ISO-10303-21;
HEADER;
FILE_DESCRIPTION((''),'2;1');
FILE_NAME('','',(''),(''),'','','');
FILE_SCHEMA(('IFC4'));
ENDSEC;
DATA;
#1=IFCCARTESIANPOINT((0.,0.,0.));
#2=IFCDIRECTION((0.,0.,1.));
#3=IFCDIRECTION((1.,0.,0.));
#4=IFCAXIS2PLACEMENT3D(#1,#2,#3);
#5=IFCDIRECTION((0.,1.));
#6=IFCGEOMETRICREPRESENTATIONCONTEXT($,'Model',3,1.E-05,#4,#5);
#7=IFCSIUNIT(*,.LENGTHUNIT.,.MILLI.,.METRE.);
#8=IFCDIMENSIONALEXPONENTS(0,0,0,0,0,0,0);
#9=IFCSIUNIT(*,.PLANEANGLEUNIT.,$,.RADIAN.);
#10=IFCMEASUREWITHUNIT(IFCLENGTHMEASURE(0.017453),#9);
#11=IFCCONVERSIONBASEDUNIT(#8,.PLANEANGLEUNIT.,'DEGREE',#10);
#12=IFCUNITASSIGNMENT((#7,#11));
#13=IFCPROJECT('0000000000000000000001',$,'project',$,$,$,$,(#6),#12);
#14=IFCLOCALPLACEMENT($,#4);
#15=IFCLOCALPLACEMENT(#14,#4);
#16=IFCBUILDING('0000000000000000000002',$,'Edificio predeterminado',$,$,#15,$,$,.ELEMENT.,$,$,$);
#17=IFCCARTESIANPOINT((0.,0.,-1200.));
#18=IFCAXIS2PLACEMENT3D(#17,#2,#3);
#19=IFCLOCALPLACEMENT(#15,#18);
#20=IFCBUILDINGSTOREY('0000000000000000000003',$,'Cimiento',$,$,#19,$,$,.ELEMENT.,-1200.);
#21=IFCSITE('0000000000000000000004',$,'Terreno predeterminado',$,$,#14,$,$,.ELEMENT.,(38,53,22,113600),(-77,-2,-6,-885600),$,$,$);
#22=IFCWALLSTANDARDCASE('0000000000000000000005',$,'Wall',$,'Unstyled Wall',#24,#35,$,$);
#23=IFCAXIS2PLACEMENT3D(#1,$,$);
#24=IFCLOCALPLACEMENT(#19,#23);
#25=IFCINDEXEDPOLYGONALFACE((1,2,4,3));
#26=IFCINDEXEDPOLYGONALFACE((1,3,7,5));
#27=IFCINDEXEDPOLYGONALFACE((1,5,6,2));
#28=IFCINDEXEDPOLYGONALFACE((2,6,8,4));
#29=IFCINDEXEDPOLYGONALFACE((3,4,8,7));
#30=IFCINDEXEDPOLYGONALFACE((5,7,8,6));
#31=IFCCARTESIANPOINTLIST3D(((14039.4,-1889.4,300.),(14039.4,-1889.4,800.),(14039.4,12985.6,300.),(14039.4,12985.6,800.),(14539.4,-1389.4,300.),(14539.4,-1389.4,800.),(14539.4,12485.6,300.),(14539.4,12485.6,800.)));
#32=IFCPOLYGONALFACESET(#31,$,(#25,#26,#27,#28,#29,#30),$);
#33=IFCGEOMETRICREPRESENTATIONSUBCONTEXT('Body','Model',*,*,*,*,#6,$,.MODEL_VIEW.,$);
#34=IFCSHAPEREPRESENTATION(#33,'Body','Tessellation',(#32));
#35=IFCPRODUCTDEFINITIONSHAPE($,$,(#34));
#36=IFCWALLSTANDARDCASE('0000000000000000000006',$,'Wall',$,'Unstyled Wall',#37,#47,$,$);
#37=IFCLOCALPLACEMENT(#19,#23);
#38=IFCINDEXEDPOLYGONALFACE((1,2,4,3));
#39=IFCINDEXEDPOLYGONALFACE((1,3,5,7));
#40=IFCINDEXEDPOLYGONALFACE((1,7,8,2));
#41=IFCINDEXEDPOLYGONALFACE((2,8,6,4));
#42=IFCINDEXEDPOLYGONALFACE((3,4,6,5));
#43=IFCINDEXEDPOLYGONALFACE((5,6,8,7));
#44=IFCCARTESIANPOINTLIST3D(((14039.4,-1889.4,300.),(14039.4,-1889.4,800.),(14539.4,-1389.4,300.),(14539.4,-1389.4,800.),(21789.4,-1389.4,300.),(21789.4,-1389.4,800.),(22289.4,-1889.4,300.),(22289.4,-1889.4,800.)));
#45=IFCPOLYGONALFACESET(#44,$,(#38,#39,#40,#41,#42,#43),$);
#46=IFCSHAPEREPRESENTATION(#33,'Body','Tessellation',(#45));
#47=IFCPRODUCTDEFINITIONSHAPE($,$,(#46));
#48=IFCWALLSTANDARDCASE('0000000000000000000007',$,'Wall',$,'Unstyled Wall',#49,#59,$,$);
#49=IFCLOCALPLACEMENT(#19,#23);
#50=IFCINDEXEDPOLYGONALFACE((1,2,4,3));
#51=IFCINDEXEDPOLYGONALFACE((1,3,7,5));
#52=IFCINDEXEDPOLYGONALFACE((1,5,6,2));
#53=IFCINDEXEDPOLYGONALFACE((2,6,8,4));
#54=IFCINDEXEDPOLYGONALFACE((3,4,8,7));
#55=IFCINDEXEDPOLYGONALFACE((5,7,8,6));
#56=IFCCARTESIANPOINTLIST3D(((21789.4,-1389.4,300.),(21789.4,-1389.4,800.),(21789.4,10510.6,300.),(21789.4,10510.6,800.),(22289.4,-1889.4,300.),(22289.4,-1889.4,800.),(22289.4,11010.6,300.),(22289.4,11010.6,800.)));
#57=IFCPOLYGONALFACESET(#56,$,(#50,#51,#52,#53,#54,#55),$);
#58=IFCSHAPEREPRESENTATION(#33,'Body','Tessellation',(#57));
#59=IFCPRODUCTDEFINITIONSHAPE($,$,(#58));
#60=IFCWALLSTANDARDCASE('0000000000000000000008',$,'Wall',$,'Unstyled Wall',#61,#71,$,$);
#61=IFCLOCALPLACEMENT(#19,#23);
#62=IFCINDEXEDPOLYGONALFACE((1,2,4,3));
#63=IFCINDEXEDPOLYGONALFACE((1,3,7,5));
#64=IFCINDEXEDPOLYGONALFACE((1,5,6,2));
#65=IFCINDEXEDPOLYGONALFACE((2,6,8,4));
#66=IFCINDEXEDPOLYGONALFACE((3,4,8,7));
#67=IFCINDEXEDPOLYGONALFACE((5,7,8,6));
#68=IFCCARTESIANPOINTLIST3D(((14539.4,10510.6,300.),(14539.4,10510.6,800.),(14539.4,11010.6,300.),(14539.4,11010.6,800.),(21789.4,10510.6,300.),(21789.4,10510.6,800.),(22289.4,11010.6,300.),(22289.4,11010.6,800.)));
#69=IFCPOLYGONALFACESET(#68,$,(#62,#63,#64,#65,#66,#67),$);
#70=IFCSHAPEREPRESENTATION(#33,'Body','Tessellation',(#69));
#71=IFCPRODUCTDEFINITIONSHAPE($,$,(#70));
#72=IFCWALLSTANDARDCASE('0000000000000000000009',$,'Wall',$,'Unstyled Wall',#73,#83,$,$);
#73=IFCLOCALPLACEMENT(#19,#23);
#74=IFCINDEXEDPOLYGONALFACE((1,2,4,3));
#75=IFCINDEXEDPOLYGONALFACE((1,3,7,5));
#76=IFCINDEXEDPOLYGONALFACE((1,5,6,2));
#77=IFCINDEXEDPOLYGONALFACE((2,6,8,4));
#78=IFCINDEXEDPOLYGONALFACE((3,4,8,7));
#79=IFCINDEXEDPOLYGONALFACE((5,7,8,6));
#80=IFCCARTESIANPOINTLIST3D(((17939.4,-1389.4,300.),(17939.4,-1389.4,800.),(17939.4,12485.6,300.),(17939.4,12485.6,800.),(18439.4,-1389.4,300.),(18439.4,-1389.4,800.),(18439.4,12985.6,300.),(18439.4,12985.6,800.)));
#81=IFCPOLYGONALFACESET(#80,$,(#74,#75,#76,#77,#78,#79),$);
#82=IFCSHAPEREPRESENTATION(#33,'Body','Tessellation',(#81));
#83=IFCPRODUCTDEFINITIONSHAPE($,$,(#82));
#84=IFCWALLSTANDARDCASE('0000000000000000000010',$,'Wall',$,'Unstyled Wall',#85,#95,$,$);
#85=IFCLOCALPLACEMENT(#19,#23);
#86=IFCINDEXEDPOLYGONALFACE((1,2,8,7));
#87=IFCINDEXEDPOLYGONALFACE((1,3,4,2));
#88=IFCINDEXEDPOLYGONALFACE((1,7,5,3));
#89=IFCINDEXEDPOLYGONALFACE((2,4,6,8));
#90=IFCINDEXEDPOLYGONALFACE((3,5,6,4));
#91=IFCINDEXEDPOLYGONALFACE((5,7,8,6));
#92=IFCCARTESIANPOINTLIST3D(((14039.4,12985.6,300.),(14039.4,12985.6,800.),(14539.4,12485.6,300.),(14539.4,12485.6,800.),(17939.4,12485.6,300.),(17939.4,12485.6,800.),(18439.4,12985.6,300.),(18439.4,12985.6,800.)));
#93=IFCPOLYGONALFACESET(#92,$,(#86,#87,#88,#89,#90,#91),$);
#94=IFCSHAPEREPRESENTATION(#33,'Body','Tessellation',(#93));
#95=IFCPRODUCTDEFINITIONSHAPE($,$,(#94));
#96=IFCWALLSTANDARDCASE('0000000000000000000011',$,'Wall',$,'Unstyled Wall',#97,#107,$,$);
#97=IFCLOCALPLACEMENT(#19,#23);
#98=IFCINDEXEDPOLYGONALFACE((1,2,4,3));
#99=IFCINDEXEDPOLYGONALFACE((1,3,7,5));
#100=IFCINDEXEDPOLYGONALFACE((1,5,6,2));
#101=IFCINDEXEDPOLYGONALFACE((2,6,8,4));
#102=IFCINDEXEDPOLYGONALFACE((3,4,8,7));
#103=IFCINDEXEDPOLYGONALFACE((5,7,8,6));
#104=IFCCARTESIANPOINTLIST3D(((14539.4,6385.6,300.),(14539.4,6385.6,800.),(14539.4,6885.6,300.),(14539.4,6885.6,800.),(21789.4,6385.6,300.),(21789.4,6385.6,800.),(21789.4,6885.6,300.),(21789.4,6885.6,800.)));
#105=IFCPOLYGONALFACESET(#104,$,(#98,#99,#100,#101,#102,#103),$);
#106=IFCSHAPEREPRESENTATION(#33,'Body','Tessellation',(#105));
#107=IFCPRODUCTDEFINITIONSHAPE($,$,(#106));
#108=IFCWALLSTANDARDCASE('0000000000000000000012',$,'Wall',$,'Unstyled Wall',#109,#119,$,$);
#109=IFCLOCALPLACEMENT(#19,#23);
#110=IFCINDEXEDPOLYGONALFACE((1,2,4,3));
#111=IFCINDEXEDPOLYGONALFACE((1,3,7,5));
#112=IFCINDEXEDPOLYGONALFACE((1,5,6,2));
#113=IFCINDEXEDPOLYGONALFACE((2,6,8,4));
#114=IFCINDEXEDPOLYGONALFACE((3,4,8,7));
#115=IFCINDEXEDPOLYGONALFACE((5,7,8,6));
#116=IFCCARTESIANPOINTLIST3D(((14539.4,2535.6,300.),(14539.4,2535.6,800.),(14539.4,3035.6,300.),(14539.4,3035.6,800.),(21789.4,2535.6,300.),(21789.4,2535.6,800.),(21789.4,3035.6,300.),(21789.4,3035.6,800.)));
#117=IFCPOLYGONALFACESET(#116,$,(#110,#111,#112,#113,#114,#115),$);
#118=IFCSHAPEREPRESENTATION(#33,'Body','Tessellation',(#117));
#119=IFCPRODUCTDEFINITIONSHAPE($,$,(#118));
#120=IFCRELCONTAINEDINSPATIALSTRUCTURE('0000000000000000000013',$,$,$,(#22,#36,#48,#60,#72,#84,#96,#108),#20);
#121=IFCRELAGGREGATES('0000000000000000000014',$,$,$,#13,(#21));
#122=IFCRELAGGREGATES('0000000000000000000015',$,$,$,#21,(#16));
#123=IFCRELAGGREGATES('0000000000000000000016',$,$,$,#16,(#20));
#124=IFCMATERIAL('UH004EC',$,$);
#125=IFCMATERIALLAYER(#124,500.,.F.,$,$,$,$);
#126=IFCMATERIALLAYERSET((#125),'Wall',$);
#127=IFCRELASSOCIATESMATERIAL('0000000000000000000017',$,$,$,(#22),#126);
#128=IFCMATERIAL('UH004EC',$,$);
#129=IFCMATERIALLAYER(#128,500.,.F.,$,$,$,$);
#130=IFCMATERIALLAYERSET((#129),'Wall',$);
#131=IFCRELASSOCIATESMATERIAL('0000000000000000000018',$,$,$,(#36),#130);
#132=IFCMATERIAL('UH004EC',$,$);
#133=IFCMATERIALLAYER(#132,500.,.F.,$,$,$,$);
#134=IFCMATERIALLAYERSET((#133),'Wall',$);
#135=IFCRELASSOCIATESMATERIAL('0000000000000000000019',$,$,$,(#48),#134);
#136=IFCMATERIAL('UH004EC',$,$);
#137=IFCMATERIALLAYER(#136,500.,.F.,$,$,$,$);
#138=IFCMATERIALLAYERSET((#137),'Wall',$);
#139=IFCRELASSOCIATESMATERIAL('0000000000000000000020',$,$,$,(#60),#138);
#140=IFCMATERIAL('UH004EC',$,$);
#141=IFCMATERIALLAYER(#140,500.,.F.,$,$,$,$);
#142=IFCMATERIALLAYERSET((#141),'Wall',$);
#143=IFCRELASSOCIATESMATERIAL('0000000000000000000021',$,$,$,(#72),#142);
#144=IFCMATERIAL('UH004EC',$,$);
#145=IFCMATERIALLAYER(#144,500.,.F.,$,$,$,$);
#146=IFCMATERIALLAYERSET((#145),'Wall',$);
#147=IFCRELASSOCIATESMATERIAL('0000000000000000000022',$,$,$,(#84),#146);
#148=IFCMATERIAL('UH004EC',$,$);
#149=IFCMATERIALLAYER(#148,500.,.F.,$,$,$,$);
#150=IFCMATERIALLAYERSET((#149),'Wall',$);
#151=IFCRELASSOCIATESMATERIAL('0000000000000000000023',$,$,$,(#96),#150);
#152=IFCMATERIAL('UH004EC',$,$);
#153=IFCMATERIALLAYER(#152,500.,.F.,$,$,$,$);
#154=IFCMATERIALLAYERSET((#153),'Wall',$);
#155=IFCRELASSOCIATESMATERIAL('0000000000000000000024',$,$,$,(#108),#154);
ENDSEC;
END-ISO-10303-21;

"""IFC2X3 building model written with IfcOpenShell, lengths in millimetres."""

from ifc_helpers import new_model, entity, si_unit, converted_unit, direction, frame, origin_with_axes, place, context, subcontext, project, spatial, polyline, outline, extrude, material, layer, layer_set, layer_usage, element, save


model = new_model("IFC2X3")

# Units and contexts
model_context = context("Model", 3, precision=1e-05, world=origin_with_axes(), true_north=direction((0.0, 1.0)))
body_context = subcontext(model_context, "Body", "Model", "MODEL_VIEW")
ifc_project = project(units=[si_unit("LENGTHUNIT", "METRE", prefix="MILLI"), converted_unit("PLANEANGLEUNIT", "DEGREE", entity("IfcLengthMeasure", 0.017453), si_unit("PLANEANGLEUNIT", "RADIAN"), dimensions=[0, 0, 0, 0, 0, 0, 0])], contexts=[model_context])

# Site, building, storey
site_placement = place(None, origin_with_axes())
site = spatial("IfcSite", under=ifc_project, at=site_placement, Name="Terreno predeterminado", CompositionType="ELEMENT", RefLatitude=(38, 53, 22, 113600), RefLongitude=(-77, -2, -6, -885600))
building_placement = place(site_placement, origin_with_axes())
building = spatial("IfcBuilding", under=site, at=building_placement, Name="Edificio predeterminado", CompositionType="ELEMENT")
storey_placement = place(building_placement, frame((0.0, 0.0, -1200.0), z_axis=(0.0, 0.0, 1.0), x_axis=(1.0, 0.0, 0.0)))
storey = spatial("IfcBuildingStorey", under=building, at=storey_placement, Name="Cimiento", CompositionType="ELEMENT", Elevation=-1200.0)

# Walls
ifc_material_1 = material(Name="UH004EC")
ifc_layer_1 = layer(ifc_material_1, 500.0, ventilated=False)
ifc_layer_set_1 = layer_set([ifc_layer_1], Name="Wall")
ifc_layer_usage_1 = layer_usage(ifc_layer_set_1, "AXIS2", "POSITIVE", -250.0)
wall_1_placement = place(storey_placement, frame((14289.4, 12735.6, 300.0), z_axis=(0.0, 0.0, 1.0), x_axis=(0.0, -1.0, 0.0)))
element("IfcWallStandardCase", 1, at=wall_1_placement, inside=storey, material=ifc_layer_usage_1, Name="Wall", ObjectType="Unstyled Wall", context=body_context, shape_type="SweptSolid", body=[
    extrude(outline(polyline([(250.0, 250.0), (-250.0, -250.0), (14625.0, -250.0), (14125.0, 250.0), (250.0, 250.0)])), origin_with_axes(), (0.0, 0.0, 1.0), 500.0),
])
ifc_material_2 = material(Name="UH004EC")
ifc_layer_2 = layer(ifc_material_2, 500.0, ventilated=False)
ifc_layer_set_2 = layer_set([ifc_layer_2], Name="Wall")
ifc_layer_usage_2 = layer_usage(ifc_layer_set_2, "AXIS2", "POSITIVE", -250.0)
wall_2_placement = place(storey_placement, frame((14289.4, -1639.4, 300.0), z_axis=(0.0, 0.0, 1.0), x_axis=(1.0, 0.0, 0.0)))
element("IfcWallStandardCase", 2, at=wall_2_placement, inside=storey, material=ifc_layer_usage_2, Name="Wall", ObjectType="Unstyled Wall", context=body_context, shape_type="SweptSolid", body=[
    extrude(outline(polyline([(-250.0, -250.0), (250.0, 250.0), (7500.0, 250.0), (8000.0, -250.0), (-250.0, -250.0)])), origin_with_axes(), (0.0, 0.0, 1.0), 500.0),
])
ifc_material_3 = material(Name="UH004EC")
ifc_layer_3 = layer(ifc_material_3, 500.0, ventilated=False)
ifc_layer_set_3 = layer_set([ifc_layer_3], Name="Wall")
ifc_layer_usage_3 = layer_usage(ifc_layer_set_3, "AXIS2", "POSITIVE", -250.0)
wall_3_placement = place(storey_placement, frame((22039.4, -1639.4, 300.0), z_axis=(0.0, 0.0, 1.0), x_axis=(0.0, 1.0, 0.0)))
element("IfcWallStandardCase", 3, at=wall_3_placement, inside=storey, material=ifc_layer_usage_3, Name="Wall", ObjectType="Unstyled Wall", context=body_context, shape_type="SweptSolid", body=[
    extrude(outline(polyline([(-250.0, -250.0), (250.0, 250.0), (12150.0, 250.0), (12650.0, -250.0), (-250.0, -250.0)])), origin_with_axes(), (0.0, 0.0, 1.0), 500.0),
])
ifc_material_4 = material(Name="UH004EC")
ifc_layer_4 = layer(ifc_material_4, 500.0, ventilated=False)
ifc_layer_set_4 = layer_set([ifc_layer_4], Name="Wall")
ifc_layer_usage_4 = layer_usage(ifc_layer_set_4, "AXIS2", "POSITIVE", -250.0)
wall_4_placement = place(storey_placement, frame((22039.4, 10760.6, 300.0), z_axis=(0.0, 0.0, 1.0), x_axis=(-1.0, 0.0, 0.0)))
element("IfcWallStandardCase", 4, at=wall_4_placement, inside=storey, material=ifc_layer_usage_4, Name="Wall", ObjectType="Unstyled Wall", context=body_context, shape_type="SweptSolid", body=[
    extrude(outline(polyline([(-250.0, -250.0), (250.0, 250.0), (7500.0, 250.0), (7500.0, -250.0), (-250.0, -250.0)])), origin_with_axes(), (0.0, 0.0, 1.0), 500.0),
])
ifc_material_5 = material(Name="UH004EC")
ifc_layer_5 = layer(ifc_material_5, 500.0, ventilated=False)
ifc_layer_set_5 = layer_set([ifc_layer_5], Name="Wall")
ifc_layer_usage_5 = layer_usage(ifc_layer_set_5, "AXIS2", "POSITIVE", -250.0)
wall_5_placement = place(storey_placement, frame((18189.4, -1639.4, 300.0), z_axis=(0.0, 0.0, 1.0), x_axis=(0.0, 1.0, 0.0)))
element("IfcWallStandardCase", 5, at=wall_5_placement, inside=storey, material=ifc_layer_usage_5, Name="Wall", ObjectType="Unstyled Wall", context=body_context, shape_type="SweptSolid", body=[
    extrude(outline(polyline([(250.0, 250.0), (250.0, -250.0), (14625.0, -250.0), (14125.0, 250.0), (250.0, 250.0)])), origin_with_axes(), (0.0, 0.0, 1.0), 500.0),
])
ifc_material_6 = material(Name="UH004EC")
ifc_layer_6 = layer(ifc_material_6, 500.0, ventilated=False)
ifc_layer_set_6 = layer_set([ifc_layer_6], Name="Wall")
ifc_layer_usage_6 = layer_usage(ifc_layer_set_6, "AXIS2", "POSITIVE", -250.0)
wall_6_placement = place(storey_placement, frame((18189.4, 12735.6, 300.0), z_axis=(0.0, 0.0, 1.0), x_axis=(-1.0, 0.0, 0.0)))
element("IfcWallStandardCase", 6, at=wall_6_placement, inside=storey, material=ifc_layer_usage_6, Name="Wall", ObjectType="Unstyled Wall", context=body_context, shape_type="SweptSolid", body=[
    extrude(outline(polyline([(-250.0, -250.0), (250.0, 250.0), (3650.0, 250.0), (4150.0, -250.0), (-250.0, -250.0)])), origin_with_axes(), (0.0, 0.0, 1.0), 500.0),
])
ifc_material_7 = material(Name="UH004EC")
ifc_layer_7 = layer(ifc_material_7, 500.0, ventilated=False)
ifc_layer_set_7 = layer_set([ifc_layer_7], Name="Wall")
ifc_layer_usage_7 = layer_usage(ifc_layer_set_7, "AXIS2", "POSITIVE", -250.0)
wall_7_placement = place(storey_placement, frame((14289.4, 6635.6, 300.0), z_axis=(0.0, 0.0, 1.0), x_axis=(1.0, 0.0, 0.0)))
element("IfcWallStandardCase", 7, at=wall_7_placement, inside=storey, material=ifc_layer_usage_7, Name="Wall", ObjectType="Unstyled Wall", context=body_context, shape_type="SweptSolid", body=[
    extrude(outline(polyline([(250.0, -250.0), (250.0, 250.0), (7500.0, 250.0), (7500.0, -250.0), (250.0, -250.0)])), origin_with_axes(), (0.0, 0.0, 1.0), 500.0),
])
ifc_material_8 = material(Name="UH004EC")
ifc_layer_8 = layer(ifc_material_8, 500.0, ventilated=False)
ifc_layer_set_8 = layer_set([ifc_layer_8], Name="Wall")
ifc_layer_usage_8 = layer_usage(ifc_layer_set_8, "AXIS2", "POSITIVE", -250.0)
wall_8_placement = place(storey_placement, frame((14289.4, 2785.6, 300.0), z_axis=(0.0, 0.0, 1.0), x_axis=(1.0, 0.0, 0.0)))
element("IfcWallStandardCase", 8, at=wall_8_placement, inside=storey, material=ifc_layer_usage_8, Name="Wall", ObjectType="Unstyled Wall", context=body_context, shape_type="SweptSolid", body=[
    extrude(outline(polyline([(250.0, -250.0), (250.0, 250.0), (7500.0, 250.0), (7500.0, -250.0), (250.0, -250.0)])), origin_with_axes(), (0.0, 0.0, 1.0), 500.0),
])

save(model, "model.ifc")
